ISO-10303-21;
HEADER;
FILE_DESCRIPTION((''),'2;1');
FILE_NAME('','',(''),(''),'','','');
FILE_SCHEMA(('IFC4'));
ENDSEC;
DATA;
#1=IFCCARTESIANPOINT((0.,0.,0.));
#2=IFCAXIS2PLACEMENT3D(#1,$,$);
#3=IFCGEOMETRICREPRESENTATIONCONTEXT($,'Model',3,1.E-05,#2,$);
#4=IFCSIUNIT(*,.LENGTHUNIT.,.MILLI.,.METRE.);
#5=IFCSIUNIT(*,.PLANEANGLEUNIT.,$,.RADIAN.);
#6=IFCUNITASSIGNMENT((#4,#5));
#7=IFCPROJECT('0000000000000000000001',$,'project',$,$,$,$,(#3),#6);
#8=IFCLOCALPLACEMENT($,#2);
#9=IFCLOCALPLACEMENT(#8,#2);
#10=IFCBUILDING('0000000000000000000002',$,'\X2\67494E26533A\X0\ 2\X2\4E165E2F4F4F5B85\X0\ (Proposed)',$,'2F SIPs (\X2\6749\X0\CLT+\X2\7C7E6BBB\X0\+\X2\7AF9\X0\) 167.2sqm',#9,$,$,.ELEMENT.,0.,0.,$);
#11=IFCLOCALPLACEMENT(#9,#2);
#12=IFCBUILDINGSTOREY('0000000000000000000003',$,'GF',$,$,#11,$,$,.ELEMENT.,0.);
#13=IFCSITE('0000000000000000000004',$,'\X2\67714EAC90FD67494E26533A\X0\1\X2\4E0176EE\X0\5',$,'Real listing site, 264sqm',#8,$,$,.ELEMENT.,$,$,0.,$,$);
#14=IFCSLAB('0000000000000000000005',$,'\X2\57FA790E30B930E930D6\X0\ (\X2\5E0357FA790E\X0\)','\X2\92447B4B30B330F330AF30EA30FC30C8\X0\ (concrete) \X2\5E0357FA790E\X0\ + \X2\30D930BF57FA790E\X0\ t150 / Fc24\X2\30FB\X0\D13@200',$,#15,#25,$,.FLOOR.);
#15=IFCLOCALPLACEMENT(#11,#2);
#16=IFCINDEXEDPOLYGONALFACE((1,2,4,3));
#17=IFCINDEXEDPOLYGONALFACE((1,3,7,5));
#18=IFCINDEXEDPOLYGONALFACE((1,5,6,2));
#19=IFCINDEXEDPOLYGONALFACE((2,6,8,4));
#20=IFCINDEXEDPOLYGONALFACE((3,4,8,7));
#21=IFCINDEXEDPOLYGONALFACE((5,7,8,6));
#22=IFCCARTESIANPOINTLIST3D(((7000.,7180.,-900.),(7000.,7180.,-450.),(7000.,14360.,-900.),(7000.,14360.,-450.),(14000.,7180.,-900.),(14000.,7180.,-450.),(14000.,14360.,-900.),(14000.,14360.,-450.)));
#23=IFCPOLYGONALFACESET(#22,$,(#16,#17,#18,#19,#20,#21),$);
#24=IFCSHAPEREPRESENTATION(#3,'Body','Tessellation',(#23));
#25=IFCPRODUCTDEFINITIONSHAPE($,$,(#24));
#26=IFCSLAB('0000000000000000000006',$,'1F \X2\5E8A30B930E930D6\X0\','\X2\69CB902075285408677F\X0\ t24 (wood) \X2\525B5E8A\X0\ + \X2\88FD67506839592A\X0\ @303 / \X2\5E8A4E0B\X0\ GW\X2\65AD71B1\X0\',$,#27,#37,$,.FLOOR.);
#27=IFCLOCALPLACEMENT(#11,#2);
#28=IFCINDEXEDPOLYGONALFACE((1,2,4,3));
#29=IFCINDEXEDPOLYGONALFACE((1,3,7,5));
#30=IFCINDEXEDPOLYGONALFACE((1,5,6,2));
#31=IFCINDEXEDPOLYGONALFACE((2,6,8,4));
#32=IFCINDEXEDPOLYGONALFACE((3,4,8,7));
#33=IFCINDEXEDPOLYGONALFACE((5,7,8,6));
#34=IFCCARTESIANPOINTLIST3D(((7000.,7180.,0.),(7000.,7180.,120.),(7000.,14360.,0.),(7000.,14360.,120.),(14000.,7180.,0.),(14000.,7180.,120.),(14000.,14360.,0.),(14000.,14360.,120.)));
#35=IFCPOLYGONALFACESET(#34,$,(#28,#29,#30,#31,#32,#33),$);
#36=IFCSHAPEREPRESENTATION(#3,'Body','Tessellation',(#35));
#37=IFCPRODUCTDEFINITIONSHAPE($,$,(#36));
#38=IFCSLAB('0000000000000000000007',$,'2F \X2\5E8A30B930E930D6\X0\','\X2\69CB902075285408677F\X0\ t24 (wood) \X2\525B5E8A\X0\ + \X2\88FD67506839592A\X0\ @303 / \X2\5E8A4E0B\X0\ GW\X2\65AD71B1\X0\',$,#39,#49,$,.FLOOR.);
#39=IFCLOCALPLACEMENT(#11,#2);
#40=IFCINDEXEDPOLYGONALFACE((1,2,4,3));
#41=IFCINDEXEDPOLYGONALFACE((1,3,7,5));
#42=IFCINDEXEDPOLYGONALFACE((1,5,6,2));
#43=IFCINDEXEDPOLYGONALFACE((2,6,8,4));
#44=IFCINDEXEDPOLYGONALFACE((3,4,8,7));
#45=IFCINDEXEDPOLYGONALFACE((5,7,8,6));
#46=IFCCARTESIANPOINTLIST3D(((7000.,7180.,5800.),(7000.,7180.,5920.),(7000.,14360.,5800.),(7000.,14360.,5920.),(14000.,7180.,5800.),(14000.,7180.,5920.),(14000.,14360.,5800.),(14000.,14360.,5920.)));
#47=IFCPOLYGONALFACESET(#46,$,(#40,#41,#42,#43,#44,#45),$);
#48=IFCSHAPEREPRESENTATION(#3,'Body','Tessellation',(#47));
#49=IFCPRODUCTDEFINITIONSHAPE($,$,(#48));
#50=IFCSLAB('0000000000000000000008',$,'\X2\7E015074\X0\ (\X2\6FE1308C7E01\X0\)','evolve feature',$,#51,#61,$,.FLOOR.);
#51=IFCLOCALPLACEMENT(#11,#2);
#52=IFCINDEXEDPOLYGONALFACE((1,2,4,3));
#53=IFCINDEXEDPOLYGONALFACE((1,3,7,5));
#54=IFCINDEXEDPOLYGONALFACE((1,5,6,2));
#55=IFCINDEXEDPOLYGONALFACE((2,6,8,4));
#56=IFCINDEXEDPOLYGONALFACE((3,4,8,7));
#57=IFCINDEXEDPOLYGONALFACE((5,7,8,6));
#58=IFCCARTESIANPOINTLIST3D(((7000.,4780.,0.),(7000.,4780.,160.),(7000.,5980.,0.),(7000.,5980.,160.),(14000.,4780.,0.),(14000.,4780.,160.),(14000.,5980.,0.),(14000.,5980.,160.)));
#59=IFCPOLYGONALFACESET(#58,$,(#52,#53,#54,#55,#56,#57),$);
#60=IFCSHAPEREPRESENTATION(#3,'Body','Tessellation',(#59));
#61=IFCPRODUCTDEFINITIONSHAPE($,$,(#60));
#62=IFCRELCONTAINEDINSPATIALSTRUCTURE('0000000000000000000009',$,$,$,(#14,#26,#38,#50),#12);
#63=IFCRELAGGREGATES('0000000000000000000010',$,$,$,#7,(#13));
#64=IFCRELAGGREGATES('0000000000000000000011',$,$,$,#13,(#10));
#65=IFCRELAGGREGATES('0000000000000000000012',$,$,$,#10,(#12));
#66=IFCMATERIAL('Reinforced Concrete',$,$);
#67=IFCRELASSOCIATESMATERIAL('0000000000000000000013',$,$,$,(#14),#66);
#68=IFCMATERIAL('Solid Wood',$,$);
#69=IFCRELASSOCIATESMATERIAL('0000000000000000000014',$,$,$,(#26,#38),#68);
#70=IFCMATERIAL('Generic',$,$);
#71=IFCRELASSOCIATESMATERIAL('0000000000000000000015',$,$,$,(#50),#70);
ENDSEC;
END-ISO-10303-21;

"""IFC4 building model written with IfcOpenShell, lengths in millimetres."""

from ifc_helpers import new_model, si_unit, frame, frame_2d, origin, place, context, project, spatial, rectangle, extrude, material, element, save


model = new_model("IFC4")

# Units and contexts
model_context = context("Model", 3, precision=1e-05, world=origin())
ifc_project = project(units=[si_unit("LENGTHUNIT", "METRE", prefix="MILLI"), si_unit("PLANEANGLEUNIT", "RADIAN")], contexts=[model_context])

# Site, building, storey
site_placement = place(None, origin())
site = spatial("IfcSite", under=ifc_project, at=site_placement, Name="東京都杉並区1丁目5", ObjectType="Real listing site, 264sqm", CompositionType="ELEMENT", RefElevation=0.0)
building_placement = place(site_placement, origin())
building = spatial("IfcBuilding", under=site, at=building_placement, Name="杉並区 2世帯住宅 (Proposed)", ObjectType="2F SIPs (杉CLT+籾殻+竹) 167.2sqm", CompositionType="ELEMENT", ElevationOfRefHeight=0.0, ElevationOfTerrain=0.0)
storey_placement = place(building_placement, origin())
storey = spatial("IfcBuildingStorey", under=building, at=storey_placement, Name="GF", CompositionType="ELEMENT", Elevation=0.0)

# Slabs
ifc_material_1 = material(Name="Reinforced Concrete")
slab_1_placement = place(storey_placement, frame((3500.0, 3590.0, -450.0)))
element("IfcSlab", 1, at=slab_1_placement, inside=storey, material=ifc_material_1, Name="基礎スラブ (布基礎)", Description="鉄筋コンクリート (concrete) 布基礎 + ベタ基礎 t150 / Fc24・D13@200", PredefinedType="FLOOR", context=model_context, shape_type="SweptSolid", body=[
    extrude(rectangle(XDim=7000.0, YDim=7180.0, at=frame_2d((3500.0, 3590.0))), frame((3500.0, 3590.0, -450.0)), (0.0, 0.0, 1.0), 450.0),
])
ifc_material_2 = material(Name="Solid Wood")
slab_2_placement = place(storey_placement, frame((3500.0, 3590.0, 0.0)))
element("IfcSlab", 2, at=slab_2_placement, inside=storey, material=ifc_material_2, Name="1F 床スラブ", Description="構造用合板 t24 (wood) 剛床 + 製材根太 @303 / 床下 GW断熱", PredefinedType="FLOOR", context=model_context, shape_type="SweptSolid", body=[
    extrude(rectangle(XDim=7000.0, YDim=7180.0, at=frame_2d((3500.0, 3590.0))), frame((3500.0, 3590.0, 0.0)), (0.0, 0.0, 1.0), 120.0),
])
slab_3_placement = place(storey_placement, frame((3500.0, 3590.0, 2900.0)))
element("IfcSlab", 3, at=slab_3_placement, inside=storey, material=ifc_material_2, Name="2F 床スラブ", Description="構造用合板 t24 (wood) 剛床 + 製材根太 @303 / 床下 GW断熱", PredefinedType="FLOOR", context=model_context, shape_type="SweptSolid", body=[
    extrude(rectangle(XDim=7000.0, YDim=7180.0, at=frame_2d((3500.0, 3590.0))), frame((3500.0, 3590.0, 2900.0)), (0.0, 0.0, 1.0), 120.0),
])
ifc_material_3 = material(Name="Generic")
slab_4_placement = place(storey_placement, frame((3500.0, 2390.0, 0.0)))
element("IfcSlab", 4, at=slab_4_placement, inside=storey, material=ifc_material_3, Name="縁側 (濡れ縁)", Description="evolve feature", PredefinedType="FLOOR", context=model_context, shape_type="SweptSolid", body=[
    extrude(rectangle(XDim=7000.0, YDim=1200.0, at=frame_2d((3500.0, 600.0))), frame((3500.0, 2390.0, 0.0)), (0.0, 0.0, 1.0), 160.0),
])

save(model, "model.ifc")
